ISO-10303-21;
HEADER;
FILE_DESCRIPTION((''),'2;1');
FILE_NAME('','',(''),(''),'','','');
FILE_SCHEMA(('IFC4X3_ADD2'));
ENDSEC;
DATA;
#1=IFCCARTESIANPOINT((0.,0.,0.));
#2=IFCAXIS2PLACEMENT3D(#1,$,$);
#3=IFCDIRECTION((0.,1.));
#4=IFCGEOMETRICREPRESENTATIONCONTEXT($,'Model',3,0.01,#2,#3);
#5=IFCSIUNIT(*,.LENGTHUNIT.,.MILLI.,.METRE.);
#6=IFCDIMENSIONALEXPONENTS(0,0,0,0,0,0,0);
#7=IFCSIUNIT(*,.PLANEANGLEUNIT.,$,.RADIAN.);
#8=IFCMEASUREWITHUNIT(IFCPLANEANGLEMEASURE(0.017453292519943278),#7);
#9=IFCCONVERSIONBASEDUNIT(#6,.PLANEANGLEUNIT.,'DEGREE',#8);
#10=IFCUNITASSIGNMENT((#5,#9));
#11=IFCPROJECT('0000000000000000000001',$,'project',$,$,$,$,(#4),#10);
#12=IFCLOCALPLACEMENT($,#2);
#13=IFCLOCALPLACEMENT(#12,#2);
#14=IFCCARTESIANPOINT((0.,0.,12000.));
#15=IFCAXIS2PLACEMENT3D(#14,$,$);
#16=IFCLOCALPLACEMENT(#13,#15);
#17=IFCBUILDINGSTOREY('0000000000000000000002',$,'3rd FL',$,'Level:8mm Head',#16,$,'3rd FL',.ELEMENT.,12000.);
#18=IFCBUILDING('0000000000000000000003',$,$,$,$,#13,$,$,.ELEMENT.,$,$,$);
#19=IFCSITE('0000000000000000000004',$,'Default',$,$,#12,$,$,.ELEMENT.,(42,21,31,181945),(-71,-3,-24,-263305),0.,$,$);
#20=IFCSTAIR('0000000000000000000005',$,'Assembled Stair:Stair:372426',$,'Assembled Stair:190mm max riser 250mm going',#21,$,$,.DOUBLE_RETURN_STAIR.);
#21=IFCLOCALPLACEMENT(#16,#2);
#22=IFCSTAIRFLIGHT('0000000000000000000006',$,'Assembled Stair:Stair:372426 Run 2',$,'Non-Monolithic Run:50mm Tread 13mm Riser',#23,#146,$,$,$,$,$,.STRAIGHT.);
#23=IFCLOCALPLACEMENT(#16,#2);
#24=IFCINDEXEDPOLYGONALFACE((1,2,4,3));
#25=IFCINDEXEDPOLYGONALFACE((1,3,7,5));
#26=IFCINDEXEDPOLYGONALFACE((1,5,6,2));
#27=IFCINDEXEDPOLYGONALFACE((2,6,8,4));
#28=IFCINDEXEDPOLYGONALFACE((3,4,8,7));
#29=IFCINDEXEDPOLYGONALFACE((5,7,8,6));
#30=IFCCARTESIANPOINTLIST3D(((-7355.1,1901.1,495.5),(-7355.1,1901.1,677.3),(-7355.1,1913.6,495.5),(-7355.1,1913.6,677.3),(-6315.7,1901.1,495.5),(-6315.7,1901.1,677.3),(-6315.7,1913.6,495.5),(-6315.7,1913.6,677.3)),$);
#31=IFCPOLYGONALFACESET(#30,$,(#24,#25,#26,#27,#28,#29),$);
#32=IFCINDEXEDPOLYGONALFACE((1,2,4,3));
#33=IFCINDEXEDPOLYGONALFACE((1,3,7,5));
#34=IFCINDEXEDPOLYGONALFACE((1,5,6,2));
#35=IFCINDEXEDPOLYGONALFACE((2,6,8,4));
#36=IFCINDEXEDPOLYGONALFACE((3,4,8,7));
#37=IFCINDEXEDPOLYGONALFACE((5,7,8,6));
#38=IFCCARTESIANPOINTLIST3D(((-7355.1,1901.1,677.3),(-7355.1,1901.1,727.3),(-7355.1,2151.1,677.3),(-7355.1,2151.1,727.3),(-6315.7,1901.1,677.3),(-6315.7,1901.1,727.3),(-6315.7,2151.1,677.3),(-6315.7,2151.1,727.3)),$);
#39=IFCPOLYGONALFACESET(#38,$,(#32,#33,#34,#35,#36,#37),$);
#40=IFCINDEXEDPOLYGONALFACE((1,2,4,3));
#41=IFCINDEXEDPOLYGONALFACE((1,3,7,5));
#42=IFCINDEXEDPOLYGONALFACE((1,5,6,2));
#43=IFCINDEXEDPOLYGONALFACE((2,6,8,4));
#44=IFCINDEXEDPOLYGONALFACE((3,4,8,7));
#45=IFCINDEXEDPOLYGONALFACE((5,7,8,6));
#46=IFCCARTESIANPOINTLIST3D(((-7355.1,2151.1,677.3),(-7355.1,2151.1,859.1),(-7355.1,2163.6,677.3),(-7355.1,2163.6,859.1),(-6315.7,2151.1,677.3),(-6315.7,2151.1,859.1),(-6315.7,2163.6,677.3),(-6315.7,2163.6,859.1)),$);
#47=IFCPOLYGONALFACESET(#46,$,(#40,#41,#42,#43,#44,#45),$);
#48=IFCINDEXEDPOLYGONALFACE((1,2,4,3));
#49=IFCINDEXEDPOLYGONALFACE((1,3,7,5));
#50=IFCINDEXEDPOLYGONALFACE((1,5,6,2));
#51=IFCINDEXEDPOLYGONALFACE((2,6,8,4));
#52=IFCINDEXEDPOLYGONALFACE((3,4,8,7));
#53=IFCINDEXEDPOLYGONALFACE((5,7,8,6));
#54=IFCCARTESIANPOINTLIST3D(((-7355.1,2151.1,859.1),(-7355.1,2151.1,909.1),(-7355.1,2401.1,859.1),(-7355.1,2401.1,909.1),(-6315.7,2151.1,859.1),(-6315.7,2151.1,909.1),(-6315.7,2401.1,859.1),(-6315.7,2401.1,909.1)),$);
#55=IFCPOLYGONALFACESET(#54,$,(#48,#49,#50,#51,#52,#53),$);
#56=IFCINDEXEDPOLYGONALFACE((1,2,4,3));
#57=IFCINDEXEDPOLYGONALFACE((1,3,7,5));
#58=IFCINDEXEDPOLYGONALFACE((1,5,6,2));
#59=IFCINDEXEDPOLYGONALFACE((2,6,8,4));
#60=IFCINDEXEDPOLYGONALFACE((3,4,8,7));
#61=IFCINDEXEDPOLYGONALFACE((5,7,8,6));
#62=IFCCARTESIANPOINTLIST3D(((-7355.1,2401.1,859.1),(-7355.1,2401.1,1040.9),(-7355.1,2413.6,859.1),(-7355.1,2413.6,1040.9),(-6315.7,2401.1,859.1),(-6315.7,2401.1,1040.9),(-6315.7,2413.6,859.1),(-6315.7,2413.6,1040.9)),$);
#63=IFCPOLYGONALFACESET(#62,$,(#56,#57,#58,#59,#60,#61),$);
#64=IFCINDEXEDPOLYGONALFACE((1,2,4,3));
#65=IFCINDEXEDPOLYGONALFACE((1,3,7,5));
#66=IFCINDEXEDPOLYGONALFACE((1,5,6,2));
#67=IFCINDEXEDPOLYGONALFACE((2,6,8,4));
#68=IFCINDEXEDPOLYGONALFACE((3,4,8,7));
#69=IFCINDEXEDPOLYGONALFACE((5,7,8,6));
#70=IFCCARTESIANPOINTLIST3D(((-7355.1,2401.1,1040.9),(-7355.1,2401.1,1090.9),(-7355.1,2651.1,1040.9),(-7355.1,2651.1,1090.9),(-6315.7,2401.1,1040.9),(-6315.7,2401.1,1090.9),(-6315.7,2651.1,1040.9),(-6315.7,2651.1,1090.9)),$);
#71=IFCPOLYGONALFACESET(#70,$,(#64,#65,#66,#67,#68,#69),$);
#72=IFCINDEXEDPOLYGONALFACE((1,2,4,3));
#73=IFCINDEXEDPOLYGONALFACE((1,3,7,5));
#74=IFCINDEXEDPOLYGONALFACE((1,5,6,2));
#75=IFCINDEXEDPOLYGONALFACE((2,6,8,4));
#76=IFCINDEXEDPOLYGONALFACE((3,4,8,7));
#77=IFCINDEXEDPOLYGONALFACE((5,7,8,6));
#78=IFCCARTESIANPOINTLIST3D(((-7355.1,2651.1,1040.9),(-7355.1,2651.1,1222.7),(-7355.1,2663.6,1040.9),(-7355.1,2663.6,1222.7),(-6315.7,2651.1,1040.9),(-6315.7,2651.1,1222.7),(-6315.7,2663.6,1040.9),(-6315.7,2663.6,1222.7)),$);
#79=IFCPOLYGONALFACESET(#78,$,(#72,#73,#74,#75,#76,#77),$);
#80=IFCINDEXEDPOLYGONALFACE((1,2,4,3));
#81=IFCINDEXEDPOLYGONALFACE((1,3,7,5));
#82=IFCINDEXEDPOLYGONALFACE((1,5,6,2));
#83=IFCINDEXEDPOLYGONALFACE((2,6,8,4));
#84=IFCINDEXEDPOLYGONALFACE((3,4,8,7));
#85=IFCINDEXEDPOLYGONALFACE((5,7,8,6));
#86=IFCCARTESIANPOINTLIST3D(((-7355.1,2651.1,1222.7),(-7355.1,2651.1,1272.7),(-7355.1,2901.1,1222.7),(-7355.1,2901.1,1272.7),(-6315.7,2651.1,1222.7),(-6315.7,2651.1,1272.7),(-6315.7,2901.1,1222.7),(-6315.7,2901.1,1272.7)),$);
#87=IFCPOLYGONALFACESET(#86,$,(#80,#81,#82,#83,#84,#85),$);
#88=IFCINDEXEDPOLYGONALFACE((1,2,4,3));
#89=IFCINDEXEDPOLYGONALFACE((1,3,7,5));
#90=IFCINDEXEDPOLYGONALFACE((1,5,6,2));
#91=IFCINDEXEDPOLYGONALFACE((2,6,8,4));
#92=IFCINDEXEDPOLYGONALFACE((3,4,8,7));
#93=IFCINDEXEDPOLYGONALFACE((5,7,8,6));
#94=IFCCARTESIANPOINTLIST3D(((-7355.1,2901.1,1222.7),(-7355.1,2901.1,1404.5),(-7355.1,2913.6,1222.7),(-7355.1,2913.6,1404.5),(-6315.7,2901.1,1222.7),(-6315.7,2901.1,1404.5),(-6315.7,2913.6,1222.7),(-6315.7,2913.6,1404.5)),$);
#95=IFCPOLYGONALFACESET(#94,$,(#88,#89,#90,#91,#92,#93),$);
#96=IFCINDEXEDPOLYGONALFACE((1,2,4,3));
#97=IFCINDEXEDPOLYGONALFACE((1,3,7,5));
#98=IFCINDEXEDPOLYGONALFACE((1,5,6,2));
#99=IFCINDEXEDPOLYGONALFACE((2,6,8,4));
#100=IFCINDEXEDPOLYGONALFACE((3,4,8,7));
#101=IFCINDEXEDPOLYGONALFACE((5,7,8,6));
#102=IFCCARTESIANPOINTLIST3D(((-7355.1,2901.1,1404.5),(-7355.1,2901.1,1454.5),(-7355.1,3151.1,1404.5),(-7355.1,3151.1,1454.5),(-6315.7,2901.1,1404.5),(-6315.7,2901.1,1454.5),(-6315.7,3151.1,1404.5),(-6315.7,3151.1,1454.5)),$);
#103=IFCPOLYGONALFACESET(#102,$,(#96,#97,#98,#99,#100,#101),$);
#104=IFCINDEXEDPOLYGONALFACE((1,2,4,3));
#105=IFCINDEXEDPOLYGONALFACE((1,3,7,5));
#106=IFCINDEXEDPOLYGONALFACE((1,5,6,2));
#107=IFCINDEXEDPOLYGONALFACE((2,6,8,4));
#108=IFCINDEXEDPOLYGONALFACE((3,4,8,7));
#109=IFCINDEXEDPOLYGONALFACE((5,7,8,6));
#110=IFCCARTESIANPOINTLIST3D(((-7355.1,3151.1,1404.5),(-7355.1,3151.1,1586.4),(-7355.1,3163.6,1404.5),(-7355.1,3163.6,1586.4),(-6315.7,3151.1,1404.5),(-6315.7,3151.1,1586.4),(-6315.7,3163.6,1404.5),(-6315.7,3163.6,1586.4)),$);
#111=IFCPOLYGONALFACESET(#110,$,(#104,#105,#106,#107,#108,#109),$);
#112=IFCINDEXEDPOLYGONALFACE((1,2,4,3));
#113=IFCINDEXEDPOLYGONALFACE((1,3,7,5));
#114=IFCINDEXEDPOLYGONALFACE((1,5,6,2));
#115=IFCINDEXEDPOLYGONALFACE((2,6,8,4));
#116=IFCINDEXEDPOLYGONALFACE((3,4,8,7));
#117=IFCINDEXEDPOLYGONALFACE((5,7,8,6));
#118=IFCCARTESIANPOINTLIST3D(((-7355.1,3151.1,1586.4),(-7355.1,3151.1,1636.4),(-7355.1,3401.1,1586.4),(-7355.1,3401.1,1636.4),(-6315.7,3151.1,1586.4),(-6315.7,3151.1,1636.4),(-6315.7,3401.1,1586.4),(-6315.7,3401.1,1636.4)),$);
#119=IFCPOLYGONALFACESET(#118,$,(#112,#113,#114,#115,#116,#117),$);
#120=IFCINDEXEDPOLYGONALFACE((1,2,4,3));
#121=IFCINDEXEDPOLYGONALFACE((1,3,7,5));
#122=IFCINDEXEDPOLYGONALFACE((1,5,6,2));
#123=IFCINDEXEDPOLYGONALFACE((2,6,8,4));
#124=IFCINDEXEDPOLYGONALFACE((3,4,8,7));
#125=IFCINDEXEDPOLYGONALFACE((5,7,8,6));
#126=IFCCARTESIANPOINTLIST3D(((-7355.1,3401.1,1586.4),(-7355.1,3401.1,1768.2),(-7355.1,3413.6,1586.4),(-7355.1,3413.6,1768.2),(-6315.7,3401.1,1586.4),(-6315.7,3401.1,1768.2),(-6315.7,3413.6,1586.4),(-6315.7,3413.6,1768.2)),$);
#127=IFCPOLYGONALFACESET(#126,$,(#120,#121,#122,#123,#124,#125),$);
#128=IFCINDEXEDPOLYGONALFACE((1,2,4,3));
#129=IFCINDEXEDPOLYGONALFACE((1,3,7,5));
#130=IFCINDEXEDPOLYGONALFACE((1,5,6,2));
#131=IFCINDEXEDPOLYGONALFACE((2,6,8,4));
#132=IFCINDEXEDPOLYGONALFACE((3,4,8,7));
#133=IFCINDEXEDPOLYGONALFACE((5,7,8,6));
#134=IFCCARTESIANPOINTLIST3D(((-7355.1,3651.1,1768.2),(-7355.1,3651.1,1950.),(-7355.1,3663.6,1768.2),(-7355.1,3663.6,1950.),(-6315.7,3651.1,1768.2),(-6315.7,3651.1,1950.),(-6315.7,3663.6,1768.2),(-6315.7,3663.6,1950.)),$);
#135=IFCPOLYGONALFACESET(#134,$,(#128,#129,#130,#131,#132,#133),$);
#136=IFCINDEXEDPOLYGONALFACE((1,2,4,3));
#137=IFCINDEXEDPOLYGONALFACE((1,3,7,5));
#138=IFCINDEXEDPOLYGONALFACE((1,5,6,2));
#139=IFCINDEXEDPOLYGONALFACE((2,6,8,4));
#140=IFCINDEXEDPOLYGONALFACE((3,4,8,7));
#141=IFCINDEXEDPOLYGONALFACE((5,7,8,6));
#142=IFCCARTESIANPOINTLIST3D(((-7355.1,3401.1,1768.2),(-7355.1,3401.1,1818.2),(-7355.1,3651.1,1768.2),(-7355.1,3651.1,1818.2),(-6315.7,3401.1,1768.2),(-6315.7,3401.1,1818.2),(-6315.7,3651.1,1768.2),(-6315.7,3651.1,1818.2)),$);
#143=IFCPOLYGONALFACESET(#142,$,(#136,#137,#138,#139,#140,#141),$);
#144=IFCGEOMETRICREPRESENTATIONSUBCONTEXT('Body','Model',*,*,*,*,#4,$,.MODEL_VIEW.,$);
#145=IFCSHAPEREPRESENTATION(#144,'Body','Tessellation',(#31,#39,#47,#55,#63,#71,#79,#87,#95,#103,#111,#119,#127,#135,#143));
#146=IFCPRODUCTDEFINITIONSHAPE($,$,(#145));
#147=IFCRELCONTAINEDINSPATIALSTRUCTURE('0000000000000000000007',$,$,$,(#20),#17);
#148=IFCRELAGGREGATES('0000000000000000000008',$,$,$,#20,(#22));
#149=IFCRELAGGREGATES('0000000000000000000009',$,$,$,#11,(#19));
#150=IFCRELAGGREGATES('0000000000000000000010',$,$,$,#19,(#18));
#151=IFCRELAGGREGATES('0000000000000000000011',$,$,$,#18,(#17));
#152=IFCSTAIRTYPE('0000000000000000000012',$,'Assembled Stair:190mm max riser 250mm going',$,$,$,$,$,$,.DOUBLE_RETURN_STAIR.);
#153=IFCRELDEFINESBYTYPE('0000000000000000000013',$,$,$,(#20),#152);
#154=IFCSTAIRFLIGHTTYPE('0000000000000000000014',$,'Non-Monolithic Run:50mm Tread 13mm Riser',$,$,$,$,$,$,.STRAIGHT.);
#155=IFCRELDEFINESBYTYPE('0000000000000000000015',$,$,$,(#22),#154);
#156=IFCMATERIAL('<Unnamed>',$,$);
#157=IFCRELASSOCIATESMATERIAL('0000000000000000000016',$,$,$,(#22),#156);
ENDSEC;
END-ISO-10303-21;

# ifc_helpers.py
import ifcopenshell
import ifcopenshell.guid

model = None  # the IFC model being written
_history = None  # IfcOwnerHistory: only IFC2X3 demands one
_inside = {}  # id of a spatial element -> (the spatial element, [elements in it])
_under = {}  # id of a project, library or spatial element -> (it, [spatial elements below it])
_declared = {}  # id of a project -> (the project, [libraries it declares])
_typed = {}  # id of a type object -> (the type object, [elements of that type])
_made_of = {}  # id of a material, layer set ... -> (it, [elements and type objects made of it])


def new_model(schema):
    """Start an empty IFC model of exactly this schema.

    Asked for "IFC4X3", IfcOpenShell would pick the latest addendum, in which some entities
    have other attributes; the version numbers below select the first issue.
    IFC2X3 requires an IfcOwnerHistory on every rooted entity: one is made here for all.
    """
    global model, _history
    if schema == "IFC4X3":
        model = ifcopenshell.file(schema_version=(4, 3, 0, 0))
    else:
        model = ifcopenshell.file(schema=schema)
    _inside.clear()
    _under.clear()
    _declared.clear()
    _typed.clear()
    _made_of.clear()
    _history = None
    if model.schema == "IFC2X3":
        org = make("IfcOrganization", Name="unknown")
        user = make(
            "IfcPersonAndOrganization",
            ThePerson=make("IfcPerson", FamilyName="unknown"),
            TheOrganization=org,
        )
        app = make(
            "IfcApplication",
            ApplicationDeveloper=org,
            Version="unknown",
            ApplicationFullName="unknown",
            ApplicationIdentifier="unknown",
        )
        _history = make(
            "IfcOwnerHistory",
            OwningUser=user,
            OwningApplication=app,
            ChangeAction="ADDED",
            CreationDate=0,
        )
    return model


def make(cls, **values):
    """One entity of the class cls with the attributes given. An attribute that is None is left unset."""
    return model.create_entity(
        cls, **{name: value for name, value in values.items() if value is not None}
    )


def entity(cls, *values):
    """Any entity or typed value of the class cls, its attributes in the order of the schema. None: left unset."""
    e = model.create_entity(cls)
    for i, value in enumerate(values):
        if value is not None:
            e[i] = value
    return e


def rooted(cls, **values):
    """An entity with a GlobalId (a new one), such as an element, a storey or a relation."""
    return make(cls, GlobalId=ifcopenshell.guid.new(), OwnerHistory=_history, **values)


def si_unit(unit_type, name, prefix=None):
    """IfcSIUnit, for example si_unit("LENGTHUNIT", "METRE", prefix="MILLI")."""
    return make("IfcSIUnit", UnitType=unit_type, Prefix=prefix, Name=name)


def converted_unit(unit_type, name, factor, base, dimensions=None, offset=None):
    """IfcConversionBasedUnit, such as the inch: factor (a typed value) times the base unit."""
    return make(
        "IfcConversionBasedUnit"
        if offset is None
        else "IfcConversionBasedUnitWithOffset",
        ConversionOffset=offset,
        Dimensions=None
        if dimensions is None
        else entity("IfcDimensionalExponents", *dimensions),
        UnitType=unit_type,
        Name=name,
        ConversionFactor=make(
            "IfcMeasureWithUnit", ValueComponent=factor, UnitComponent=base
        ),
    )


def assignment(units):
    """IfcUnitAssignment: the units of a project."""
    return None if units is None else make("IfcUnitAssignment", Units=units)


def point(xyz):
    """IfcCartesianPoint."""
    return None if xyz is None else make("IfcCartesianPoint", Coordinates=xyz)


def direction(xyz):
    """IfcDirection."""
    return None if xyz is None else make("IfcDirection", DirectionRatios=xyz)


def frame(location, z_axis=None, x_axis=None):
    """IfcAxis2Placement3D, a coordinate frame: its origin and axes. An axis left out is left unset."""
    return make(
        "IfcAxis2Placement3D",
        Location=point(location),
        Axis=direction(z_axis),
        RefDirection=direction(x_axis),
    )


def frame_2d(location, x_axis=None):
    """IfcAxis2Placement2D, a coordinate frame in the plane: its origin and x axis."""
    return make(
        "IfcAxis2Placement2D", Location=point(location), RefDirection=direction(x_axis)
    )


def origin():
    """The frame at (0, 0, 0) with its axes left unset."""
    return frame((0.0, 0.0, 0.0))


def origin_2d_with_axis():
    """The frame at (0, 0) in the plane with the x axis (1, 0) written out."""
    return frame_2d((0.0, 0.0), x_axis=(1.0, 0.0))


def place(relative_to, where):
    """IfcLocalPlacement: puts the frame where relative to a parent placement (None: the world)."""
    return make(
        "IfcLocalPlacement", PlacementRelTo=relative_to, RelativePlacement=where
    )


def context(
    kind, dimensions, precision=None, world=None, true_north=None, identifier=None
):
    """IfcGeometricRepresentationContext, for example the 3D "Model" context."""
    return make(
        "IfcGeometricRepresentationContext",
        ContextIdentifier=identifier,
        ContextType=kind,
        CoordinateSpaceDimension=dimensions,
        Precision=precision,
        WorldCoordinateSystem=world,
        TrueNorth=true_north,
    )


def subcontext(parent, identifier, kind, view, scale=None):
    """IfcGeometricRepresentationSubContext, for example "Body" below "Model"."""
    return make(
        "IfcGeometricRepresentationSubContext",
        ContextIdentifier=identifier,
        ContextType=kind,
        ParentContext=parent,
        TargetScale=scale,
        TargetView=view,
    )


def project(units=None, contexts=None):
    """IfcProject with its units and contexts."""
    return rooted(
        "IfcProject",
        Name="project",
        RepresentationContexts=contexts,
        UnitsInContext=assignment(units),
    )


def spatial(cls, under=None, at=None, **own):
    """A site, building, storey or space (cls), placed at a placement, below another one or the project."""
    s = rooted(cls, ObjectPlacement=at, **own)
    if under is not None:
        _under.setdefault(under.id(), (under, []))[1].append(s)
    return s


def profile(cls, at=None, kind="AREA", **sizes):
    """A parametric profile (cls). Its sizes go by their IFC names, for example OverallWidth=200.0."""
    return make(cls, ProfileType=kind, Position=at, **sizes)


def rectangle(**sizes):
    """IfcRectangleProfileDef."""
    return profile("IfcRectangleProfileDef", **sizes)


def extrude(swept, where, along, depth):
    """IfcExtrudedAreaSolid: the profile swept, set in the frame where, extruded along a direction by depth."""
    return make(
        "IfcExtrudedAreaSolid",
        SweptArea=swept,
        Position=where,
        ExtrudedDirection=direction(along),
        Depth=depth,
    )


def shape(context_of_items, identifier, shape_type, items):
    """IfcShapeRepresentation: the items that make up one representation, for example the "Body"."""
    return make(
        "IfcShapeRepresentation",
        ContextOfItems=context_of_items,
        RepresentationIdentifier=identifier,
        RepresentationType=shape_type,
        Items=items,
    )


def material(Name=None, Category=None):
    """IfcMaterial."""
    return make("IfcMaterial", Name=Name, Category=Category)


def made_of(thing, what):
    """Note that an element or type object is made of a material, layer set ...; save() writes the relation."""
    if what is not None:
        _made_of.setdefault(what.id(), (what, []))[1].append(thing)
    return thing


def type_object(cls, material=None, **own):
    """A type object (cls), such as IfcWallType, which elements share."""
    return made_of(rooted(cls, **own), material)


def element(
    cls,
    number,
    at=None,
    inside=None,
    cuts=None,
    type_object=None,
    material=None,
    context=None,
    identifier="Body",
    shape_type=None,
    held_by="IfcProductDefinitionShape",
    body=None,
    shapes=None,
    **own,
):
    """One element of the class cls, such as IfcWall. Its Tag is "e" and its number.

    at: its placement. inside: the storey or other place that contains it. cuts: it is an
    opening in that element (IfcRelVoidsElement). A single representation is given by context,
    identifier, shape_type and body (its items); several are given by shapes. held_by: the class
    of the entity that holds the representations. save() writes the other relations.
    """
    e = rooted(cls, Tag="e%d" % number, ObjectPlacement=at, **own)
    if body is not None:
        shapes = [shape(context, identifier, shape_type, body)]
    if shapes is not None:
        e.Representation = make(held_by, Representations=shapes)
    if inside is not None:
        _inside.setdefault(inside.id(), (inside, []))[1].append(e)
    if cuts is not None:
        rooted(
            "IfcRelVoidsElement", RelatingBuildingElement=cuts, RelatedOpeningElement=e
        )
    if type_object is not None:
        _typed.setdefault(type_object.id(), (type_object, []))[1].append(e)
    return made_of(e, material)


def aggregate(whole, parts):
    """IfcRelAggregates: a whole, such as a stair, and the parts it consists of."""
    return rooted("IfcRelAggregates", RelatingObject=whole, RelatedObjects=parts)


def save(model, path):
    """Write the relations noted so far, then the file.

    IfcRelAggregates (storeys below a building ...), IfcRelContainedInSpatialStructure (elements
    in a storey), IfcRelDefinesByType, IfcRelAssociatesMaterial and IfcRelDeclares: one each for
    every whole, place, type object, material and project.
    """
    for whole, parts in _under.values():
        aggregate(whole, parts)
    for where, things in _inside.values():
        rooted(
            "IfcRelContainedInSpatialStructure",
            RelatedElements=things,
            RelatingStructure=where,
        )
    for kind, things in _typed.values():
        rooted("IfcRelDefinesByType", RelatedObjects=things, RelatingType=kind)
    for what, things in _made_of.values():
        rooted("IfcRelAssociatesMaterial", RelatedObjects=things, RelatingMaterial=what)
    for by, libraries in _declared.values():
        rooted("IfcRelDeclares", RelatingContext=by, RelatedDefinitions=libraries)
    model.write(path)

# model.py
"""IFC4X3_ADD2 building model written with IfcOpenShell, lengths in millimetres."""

from ifc_helpers import new_model, entity, si_unit, converted_unit, direction, frame, frame_2d, origin, origin_2d_with_axis, place, context, subcontext, project, spatial, rectangle, extrude, material, type_object, element, aggregate, save


model = new_model("IFC4X3_ADD2")

# Units and contexts
model_context = context("Model", 3, precision=0.01, world=origin(), true_north=direction((0.0, 1.0)))
body_context = subcontext(model_context, "Body", "Model", "MODEL_VIEW")
ifc_project = project(units=[si_unit("LENGTHUNIT", "METRE", prefix="MILLI"), converted_unit("PLANEANGLEUNIT", "DEGREE", entity("IfcPlaneAngleMeasure", 0.017453292519943278), si_unit("PLANEANGLEUNIT", "RADIAN"), dimensions=[0, 0, 0, 0, 0, 0, 0])], contexts=[model_context])

# Site, building, storey
site_placement = place(None, origin())
site = spatial("IfcSite", under=ifc_project, at=site_placement, Name="Default", CompositionType="ELEMENT", RefLatitude=(42, 21, 31, 181945), RefLongitude=(-71, -3, -24, -263305), RefElevation=0.0)
building_placement = place(site_placement, origin())
building = spatial("IfcBuilding", under=site, at=building_placement, CompositionType="ELEMENT")
storey_placement = place(building_placement, frame((0.0, 0.0, 12000.0)))
storey = spatial("IfcBuildingStorey", under=building, at=storey_placement, Name="3rd FL", ObjectType="Level:8mm Head", LongName="3rd FL", CompositionType="ELEMENT", Elevation=12000.0)

# Stair
stair_type = type_object("IfcStairType", Name="Assembled Stair:190mm max riser 250mm going", PredefinedType="DOUBLE_RETURN_STAIR")
stair_placement = place(storey_placement, origin())
stair = element("IfcStair", 1, at=stair_placement, inside=storey, type_object=stair_type, Name="Assembled Stair:Stair:372426", ObjectType="Assembled Stair:190mm max riser 250mm going", PredefinedType="DOUBLE_RETURN_STAIR")
ifc_material_1 = material(Name="<Unnamed>")

# Stair flight
stair_flight_type = type_object("IfcStairFlightType", Name="Non-Monolithic Run:50mm Tread 13mm Riser", PredefinedType="STRAIGHT")
stair_flight_1_placement = place(stair_placement, frame((-7355.1, 1901.1, 0.0)))
stair_flight_1 = element("IfcStairFlight", 2, at=stair_flight_1_placement, type_object=stair_flight_type, material=ifc_material_1, Name="Assembled Stair:Stair:372426 Run 2", ObjectType="Non-Monolithic Run:50mm Tread 13mm Riser", PredefinedType="STRAIGHT", context=body_context, shape_type="SweptSolid", body=[
    extrude(rectangle(XDim=1039.4, YDim=12.5, at=frame_2d((0.0, 0.0), x_axis=(1.0, 0.0))), frame((519.7, 6.2, 495.5), z_axis=(0.0, 0.0, 1.0), x_axis=(-1.0, 0.0, 0.0)), (0.0, 0.0, 1.0), 181.8),
    extrude(rectangle(XDim=250.0, YDim=1039.4, at=frame_2d((0.0, 0.0), x_axis=(1.0, 0.0))), frame((519.7, 125.0, 677.3), z_axis=(0.0, 0.0, 1.0), x_axis=(0.0, -1.0, 0.0)), (0.0, 0.0, 1.0), 50.0),
    extrude(rectangle(XDim=1039.4, YDim=12.5, at=frame_2d((0.0, 0.0), x_axis=(1.0, 0.0))), frame((519.7, 256.2, 677.3), z_axis=(0.0, 0.0, 1.0), x_axis=(-1.0, 0.0, 0.0)), (0.0, 0.0, 1.0), 181.8),
    extrude(rectangle(XDim=250.0, YDim=1039.4, at=frame_2d((0.0, 0.0), x_axis=(1.0, 0.0))), frame((519.7, 375.0, 859.1), z_axis=(0.0, 0.0, 1.0), x_axis=(0.0, -1.0, 0.0)), (0.0, 0.0, 1.0), 50.0),
    extrude(rectangle(XDim=1039.4, YDim=12.5, at=frame_2d((0.0, 0.0), x_axis=(1.0, 0.0))), frame((519.7, 506.3, 859.1), z_axis=(0.0, 0.0, 1.0), x_axis=(-1.0, 0.0, 0.0)), (0.0, 0.0, 1.0), 181.8),
    extrude(rectangle(XDim=250.0, YDim=1039.4, at=frame_2d((0.0, 0.0), x_axis=(1.0, 0.0))), frame((519.7, 625.0, 1040.9), z_axis=(0.0, 0.0, 1.0), x_axis=(0.0, -1.0, 0.0)), (0.0, 0.0, 1.0), 50.0),
    extrude(rectangle(XDim=1039.4, YDim=12.5, at=frame_2d((0.0, 0.0), x_axis=(1.0, 0.0))), frame((519.7, 756.3, 1040.9), z_axis=(0.0, 0.0, 1.0), x_axis=(-1.0, 0.0, 0.0)), (0.0, 0.0, 1.0), 181.8),
    extrude(rectangle(XDim=250.0, YDim=1039.4, at=frame_2d((0.0, 0.0), x_axis=(1.0, 0.0))), frame((519.7, 875.0, 1222.7), z_axis=(0.0, 0.0, 1.0), x_axis=(0.0, -1.0, 0.0)), (0.0, 0.0, 1.0), 50.0),
    extrude(rectangle(XDim=1039.4, YDim=12.5, at=origin_2d_with_axis()), frame((519.7, 1006.3, 1222.7), z_axis=(0.0, 0.0, 1.0), x_axis=(-1.0, 0.0, 0.0)), (0.0, 0.0, 1.0), 181.8),
    extrude(rectangle(XDim=250.0, YDim=1039.4, at=frame_2d((0.0, 0.0), x_axis=(1.0, 0.0))), frame((519.7, 1125.0, 1404.5), z_axis=(0.0, 0.0, 1.0), x_axis=(0.0, -1.0, 0.0)), (0.0, 0.0, 1.0), 50.0),
    extrude(rectangle(XDim=1039.4, YDim=12.5, at=origin_2d_with_axis()), frame((519.7, 1256.3, 1404.5), z_axis=(0.0, 0.0, 1.0), x_axis=(-1.0, 0.0, 0.0)), (0.0, 0.0, 1.0), 181.8),
    extrude(rectangle(XDim=250.0, YDim=1039.4, at=frame_2d((0.0, 0.0), x_axis=(1.0, 0.0))), frame((519.7, 1375.0, 1586.4), z_axis=(0.0, 0.0, 1.0), x_axis=(0.0, -1.0, 0.0)), (0.0, 0.0, 1.0), 50.0),
    extrude(rectangle(XDim=1039.4, YDim=12.5, at=origin_2d_with_axis()), frame((519.7, 1506.3, 1586.4), z_axis=(0.0, 0.0, 1.0), x_axis=(-1.0, 0.0, 0.0)), (0.0, 0.0, 1.0), 181.8),
    extrude(rectangle(XDim=1039.4, YDim=12.5, at=frame_2d((0.0, 0.0), x_axis=(1.0, 0.0))), frame((519.7, 1756.2, 1768.2), z_axis=(0.0, 0.0, 1.0), x_axis=(-1.0, 0.0, 0.0)), (0.0, 0.0, 1.0), 181.8),
    extrude(rectangle(XDim=250.0, YDim=1039.4, at=frame_2d((0.0, 0.0), x_axis=(1.0, 0.0))), frame((519.7, 1625.0, 1768.2), z_axis=(0.0, 0.0, 1.0), x_axis=(0.0, -1.0, 0.0)), (0.0, 0.0, 1.0), 50.0),
])
aggregate(stair, [stair_flight_1])

save(model, "model.ifc")
